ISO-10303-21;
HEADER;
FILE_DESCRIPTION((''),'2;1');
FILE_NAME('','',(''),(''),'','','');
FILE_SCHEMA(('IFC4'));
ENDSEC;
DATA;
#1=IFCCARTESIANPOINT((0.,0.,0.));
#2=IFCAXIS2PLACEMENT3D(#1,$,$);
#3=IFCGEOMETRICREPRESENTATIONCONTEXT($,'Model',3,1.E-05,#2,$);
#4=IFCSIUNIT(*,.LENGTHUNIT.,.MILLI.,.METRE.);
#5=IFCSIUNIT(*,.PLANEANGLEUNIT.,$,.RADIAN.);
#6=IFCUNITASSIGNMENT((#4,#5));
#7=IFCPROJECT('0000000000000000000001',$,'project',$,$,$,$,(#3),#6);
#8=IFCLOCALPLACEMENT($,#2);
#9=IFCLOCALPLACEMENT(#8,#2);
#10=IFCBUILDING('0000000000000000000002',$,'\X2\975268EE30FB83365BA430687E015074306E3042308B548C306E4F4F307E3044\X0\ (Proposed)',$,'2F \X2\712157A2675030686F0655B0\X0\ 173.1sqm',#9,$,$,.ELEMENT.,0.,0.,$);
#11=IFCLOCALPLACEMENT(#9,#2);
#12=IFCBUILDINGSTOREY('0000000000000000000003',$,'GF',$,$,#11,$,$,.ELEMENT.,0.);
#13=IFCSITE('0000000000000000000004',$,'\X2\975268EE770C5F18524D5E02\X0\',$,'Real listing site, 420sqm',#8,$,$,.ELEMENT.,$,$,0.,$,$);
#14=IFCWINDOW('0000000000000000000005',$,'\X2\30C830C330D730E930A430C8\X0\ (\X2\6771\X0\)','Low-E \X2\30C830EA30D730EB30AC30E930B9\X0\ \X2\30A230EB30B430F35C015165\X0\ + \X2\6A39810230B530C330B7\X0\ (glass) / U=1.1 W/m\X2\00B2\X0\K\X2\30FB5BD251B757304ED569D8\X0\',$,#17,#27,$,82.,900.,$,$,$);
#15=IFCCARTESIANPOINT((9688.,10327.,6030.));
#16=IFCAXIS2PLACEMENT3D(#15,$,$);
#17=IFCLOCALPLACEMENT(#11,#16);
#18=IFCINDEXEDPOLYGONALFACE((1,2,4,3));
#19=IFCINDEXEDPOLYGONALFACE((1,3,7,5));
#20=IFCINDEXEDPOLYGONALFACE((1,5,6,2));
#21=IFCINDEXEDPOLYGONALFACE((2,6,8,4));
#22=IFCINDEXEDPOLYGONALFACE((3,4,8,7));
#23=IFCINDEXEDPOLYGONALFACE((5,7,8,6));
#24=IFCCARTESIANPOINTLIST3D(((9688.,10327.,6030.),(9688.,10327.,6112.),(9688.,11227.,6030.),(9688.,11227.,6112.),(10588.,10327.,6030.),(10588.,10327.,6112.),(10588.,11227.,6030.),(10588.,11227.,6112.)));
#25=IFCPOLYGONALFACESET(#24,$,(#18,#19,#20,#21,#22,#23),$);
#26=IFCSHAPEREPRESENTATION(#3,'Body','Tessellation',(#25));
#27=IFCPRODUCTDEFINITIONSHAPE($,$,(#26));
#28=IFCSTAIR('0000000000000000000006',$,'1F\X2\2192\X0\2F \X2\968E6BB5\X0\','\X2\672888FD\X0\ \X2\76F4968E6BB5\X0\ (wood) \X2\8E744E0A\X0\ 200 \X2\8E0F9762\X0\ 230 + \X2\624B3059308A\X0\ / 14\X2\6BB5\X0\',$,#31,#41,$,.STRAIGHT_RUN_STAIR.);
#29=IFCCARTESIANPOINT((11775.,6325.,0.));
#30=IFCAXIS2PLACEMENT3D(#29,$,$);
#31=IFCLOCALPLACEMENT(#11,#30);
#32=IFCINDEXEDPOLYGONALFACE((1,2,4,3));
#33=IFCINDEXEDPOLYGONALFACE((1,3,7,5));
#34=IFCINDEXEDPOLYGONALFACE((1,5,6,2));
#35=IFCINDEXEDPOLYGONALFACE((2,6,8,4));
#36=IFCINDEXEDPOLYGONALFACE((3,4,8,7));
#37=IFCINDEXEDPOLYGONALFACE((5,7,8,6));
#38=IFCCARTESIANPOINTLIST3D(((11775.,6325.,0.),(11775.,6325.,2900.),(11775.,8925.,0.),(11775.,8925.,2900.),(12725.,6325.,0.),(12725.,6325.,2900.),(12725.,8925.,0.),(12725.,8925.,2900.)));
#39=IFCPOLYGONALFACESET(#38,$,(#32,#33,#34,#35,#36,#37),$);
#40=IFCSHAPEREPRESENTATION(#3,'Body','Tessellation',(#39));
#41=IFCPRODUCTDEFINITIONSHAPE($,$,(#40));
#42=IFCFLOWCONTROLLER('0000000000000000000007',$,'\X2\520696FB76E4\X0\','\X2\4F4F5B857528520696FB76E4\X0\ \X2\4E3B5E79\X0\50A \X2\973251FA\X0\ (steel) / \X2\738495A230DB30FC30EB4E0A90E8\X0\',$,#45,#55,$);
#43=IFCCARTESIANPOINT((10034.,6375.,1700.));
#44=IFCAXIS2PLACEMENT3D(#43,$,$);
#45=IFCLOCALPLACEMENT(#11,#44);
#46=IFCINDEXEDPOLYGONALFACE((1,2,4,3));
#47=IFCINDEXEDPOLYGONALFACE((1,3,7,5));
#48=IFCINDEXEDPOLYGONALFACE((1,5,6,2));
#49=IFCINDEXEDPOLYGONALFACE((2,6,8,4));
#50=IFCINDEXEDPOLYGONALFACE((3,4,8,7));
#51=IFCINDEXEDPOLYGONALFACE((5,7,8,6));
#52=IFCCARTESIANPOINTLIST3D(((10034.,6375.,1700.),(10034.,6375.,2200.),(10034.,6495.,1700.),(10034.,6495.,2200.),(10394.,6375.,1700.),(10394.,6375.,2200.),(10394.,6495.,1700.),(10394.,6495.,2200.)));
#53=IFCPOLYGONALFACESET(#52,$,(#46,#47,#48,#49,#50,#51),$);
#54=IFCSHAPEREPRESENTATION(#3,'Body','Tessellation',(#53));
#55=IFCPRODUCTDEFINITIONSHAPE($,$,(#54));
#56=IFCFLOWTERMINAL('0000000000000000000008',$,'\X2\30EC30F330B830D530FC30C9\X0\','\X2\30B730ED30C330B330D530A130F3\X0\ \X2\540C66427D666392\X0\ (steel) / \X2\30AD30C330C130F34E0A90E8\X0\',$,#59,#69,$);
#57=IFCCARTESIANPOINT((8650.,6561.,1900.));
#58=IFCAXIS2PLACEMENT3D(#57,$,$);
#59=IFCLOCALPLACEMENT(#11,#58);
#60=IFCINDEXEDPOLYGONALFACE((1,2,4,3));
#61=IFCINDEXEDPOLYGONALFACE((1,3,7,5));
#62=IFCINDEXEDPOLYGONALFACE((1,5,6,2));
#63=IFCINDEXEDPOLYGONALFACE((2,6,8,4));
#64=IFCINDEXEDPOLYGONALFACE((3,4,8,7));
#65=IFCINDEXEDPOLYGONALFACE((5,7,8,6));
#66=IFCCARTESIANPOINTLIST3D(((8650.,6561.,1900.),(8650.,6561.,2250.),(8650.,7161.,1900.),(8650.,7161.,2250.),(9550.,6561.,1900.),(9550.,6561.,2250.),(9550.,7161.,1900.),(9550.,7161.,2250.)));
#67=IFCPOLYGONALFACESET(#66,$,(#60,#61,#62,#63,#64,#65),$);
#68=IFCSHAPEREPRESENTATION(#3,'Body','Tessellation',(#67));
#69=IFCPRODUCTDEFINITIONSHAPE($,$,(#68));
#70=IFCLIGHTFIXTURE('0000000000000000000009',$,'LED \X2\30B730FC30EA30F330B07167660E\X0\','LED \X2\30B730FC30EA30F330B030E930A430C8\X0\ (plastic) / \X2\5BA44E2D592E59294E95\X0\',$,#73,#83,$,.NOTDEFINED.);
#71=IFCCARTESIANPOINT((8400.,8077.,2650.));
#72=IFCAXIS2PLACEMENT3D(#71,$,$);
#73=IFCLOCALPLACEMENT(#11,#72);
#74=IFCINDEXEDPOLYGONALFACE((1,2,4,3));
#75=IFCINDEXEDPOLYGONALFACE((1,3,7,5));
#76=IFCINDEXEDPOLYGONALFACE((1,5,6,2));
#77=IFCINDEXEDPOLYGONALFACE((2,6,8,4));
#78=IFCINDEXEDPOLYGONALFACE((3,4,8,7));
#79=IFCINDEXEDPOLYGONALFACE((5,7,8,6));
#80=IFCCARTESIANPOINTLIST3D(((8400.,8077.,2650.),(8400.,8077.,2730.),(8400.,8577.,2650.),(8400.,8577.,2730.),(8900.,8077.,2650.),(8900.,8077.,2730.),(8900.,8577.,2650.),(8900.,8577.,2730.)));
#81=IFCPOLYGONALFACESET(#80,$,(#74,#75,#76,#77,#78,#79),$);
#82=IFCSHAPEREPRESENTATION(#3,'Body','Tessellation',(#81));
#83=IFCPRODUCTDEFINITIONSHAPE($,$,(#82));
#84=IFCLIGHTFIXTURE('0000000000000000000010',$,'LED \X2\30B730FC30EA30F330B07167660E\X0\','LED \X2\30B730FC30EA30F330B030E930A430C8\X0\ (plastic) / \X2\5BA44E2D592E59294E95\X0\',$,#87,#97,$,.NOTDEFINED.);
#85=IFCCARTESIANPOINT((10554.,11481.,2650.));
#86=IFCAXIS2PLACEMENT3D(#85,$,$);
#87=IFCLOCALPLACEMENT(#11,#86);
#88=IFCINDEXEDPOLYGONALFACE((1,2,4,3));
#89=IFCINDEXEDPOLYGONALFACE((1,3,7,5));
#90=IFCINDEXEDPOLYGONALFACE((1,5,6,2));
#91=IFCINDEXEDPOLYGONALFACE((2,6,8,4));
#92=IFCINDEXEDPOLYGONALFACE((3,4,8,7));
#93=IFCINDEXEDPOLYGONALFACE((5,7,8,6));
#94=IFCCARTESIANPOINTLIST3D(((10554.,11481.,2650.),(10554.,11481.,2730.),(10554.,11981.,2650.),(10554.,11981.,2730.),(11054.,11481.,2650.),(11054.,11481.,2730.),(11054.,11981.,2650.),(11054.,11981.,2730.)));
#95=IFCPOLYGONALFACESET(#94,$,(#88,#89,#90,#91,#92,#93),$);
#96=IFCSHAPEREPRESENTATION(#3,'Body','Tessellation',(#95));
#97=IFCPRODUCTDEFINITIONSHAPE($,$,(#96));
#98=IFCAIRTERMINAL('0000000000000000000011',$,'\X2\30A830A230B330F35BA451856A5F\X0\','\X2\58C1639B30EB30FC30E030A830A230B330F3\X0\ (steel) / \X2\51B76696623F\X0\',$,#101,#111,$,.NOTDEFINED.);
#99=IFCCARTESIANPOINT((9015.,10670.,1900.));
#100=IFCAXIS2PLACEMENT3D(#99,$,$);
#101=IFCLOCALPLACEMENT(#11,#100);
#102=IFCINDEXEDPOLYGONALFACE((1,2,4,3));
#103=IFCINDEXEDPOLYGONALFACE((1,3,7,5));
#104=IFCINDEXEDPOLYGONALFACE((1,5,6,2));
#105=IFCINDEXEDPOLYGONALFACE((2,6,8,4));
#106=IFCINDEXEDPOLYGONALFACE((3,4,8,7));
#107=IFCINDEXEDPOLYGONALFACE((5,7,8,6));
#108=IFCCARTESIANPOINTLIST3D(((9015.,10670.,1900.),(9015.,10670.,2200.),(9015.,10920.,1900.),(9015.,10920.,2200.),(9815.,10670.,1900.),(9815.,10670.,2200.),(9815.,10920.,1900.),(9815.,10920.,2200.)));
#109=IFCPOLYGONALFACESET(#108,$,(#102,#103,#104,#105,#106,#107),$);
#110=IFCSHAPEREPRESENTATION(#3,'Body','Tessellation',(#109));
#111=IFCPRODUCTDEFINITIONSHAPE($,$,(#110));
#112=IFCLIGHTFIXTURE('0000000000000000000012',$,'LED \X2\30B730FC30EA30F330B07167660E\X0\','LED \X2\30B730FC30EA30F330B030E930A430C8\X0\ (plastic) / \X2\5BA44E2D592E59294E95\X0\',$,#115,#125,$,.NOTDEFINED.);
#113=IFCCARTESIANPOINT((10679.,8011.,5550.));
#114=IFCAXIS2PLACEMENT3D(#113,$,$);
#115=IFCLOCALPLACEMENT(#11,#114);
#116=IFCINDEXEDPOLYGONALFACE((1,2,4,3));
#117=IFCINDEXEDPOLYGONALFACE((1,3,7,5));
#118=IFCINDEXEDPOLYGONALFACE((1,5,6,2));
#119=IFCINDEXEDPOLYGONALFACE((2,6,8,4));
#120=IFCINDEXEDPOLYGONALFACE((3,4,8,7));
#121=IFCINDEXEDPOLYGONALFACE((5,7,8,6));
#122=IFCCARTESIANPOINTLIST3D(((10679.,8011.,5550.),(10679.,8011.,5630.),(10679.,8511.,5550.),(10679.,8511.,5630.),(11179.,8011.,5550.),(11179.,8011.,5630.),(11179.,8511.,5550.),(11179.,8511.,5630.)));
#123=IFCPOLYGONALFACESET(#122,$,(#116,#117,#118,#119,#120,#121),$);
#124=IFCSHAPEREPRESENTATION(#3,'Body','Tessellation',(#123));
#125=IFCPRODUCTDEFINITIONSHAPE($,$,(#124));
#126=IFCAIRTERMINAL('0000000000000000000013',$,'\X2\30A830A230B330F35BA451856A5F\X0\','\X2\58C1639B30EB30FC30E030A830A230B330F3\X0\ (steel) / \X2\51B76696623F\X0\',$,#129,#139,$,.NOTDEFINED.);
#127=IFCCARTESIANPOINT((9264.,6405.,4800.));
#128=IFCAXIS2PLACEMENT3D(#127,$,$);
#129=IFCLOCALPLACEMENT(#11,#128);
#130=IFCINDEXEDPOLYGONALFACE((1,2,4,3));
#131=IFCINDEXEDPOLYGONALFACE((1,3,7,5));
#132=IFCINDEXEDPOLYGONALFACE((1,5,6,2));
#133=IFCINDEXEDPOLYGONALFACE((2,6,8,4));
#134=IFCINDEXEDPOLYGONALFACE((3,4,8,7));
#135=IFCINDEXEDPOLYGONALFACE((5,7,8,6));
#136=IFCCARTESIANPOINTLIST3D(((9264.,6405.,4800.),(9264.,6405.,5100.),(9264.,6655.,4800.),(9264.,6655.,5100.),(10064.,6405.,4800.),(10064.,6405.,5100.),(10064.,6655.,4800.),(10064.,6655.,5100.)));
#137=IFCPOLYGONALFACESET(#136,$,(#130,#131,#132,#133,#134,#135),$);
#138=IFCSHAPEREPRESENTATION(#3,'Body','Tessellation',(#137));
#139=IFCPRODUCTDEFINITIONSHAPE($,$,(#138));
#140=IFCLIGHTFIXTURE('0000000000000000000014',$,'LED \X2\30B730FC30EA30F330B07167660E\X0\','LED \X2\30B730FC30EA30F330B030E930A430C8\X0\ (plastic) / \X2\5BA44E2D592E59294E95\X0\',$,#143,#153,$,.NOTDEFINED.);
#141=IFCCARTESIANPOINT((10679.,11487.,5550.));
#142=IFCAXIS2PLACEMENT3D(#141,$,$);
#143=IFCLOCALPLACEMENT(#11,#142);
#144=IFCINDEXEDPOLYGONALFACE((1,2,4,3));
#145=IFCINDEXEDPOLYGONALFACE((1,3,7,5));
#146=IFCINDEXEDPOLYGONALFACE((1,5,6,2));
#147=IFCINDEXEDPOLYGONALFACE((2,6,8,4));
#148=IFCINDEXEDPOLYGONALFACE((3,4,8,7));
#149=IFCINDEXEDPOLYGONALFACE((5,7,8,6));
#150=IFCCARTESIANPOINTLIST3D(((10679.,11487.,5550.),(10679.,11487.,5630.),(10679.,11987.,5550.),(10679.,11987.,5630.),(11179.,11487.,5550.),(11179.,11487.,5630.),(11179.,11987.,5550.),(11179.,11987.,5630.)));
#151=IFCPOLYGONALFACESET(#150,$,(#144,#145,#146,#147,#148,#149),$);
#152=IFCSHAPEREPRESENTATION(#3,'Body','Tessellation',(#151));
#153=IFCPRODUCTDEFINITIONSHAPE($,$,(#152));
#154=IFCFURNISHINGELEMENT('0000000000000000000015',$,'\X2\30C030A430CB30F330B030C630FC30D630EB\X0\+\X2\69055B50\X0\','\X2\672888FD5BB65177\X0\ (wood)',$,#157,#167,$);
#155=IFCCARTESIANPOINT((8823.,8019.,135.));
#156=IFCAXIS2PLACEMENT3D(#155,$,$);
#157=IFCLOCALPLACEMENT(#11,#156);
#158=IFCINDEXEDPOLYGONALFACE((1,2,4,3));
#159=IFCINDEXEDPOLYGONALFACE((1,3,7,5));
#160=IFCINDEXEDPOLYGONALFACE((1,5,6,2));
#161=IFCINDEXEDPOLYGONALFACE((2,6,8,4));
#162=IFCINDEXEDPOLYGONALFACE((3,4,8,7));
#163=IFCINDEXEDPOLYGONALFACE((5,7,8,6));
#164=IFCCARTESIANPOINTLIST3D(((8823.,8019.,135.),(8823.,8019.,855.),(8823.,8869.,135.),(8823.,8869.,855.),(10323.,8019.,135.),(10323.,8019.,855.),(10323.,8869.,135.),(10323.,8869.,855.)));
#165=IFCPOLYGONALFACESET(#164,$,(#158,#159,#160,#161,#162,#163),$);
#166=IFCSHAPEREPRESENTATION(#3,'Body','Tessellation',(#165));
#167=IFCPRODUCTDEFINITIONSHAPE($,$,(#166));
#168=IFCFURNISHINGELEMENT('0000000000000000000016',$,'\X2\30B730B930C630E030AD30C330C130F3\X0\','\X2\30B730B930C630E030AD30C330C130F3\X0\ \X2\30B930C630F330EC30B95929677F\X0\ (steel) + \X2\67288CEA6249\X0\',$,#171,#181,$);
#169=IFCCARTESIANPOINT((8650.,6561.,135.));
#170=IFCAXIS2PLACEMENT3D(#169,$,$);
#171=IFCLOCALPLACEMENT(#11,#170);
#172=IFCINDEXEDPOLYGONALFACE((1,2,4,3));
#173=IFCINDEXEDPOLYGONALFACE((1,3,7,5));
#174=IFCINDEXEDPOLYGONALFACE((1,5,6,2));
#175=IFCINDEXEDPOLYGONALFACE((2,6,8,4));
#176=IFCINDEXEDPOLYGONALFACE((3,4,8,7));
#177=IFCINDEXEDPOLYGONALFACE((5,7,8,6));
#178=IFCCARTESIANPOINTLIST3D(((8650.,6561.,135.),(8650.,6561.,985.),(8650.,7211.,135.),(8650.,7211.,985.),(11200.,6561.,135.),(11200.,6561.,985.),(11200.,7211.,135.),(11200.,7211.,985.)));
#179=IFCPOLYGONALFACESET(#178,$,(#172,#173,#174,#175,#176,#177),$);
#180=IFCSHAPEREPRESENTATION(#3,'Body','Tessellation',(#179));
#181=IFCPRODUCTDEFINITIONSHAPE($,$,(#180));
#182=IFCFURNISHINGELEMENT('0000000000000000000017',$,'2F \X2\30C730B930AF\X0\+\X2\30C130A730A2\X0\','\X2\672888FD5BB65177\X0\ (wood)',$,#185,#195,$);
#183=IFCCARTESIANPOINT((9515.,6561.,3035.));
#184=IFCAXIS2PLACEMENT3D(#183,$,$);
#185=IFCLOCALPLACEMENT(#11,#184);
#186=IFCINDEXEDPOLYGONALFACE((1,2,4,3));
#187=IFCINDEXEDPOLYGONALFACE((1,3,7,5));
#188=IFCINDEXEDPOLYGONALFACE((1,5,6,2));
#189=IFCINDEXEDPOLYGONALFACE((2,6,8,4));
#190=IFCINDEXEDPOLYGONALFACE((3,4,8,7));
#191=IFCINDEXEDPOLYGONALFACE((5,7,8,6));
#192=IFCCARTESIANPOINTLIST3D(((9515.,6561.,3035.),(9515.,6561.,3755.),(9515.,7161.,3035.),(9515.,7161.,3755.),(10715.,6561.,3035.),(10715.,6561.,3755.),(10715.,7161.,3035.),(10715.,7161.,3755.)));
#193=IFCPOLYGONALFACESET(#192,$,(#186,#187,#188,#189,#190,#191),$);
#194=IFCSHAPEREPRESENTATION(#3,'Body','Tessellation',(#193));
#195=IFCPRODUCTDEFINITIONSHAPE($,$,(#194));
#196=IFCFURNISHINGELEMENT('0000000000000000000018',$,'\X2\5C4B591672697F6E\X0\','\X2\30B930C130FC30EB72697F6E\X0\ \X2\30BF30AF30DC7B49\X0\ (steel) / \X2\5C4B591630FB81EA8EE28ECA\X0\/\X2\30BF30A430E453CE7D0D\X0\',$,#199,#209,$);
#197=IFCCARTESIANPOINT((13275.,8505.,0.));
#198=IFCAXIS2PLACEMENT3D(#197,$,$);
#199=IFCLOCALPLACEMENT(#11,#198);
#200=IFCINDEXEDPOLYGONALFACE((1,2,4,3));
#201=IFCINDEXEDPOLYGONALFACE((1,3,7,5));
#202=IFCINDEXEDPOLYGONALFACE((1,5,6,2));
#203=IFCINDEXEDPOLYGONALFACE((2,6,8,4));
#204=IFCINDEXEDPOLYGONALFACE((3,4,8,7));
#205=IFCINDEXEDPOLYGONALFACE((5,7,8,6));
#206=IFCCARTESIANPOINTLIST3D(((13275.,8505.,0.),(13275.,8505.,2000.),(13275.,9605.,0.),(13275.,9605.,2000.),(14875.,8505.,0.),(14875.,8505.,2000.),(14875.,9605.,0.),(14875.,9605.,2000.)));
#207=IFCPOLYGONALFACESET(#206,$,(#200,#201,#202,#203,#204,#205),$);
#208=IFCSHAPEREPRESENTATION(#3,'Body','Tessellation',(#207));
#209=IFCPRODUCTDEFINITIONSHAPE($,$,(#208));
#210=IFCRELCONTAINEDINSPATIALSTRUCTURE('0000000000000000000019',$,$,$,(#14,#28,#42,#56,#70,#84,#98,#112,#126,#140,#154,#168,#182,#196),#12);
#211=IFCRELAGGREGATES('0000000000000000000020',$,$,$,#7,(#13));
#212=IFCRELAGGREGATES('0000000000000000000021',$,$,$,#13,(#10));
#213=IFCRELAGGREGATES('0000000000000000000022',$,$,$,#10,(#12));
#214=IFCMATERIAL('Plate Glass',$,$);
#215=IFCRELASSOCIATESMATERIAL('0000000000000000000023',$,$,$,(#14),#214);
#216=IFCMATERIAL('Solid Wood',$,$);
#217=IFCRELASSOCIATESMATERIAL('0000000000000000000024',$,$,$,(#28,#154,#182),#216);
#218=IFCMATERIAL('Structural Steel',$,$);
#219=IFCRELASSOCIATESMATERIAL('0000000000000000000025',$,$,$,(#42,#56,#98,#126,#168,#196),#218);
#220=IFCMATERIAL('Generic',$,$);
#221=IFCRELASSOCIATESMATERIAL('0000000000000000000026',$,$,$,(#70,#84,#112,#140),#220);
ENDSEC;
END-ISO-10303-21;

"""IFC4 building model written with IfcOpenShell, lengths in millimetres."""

from ifc_helpers import new_model, si_unit, frame, frame_2d, origin, place, context, project, spatial, rectangle, extrude, material, element, save


model = new_model("IFC4")

# Units and contexts
model_context = context("Model", 3, precision=1e-05, world=origin())
ifc_project = project(units=[si_unit("LENGTHUNIT", "METRE", prefix="MILLI"), si_unit("PLANEANGLEUNIT", "RADIAN")], contexts=[model_context])

# Site, building, storey
site_placement = place(None, origin())
site = spatial("IfcSite", under=ifc_project, at=site_placement, Name="青森県弘前市", ObjectType="Real listing site, 420sqm", CompositionType="ELEMENT", RefElevation=0.0)
building_placement = place(site_placement, origin())
building = spatial("IfcBuilding", under=site, at=building_placement, Name="青森・茶室と縁側のある和の住まい (Proposed)", ObjectType="2F 無垢材と漆喰 173.1sqm", CompositionType="ELEMENT", ElevationOfRefHeight=0.0, ElevationOfTerrain=0.0)
storey_placement = place(building_placement, origin())
storey = spatial("IfcBuildingStorey", under=building, at=storey_placement, Name="GF", CompositionType="ELEMENT", Elevation=0.0)

# Shared definitions
ifc_material_1 = material(Name="Solid Wood")

# Window
ifc_material_2 = material(Name="Plate Glass")
window_placement = place(storey_placement, frame((9688.0, 10327.0, 6030.0)))
element("IfcWindow", 1, at=window_placement, inside=storey, material=ifc_material_2, Name="トップライト (東)", Description="Low-E トリプルガラス アルゴン封入 + 樹脂サッシ (glass) / U=1.1 W/m²K・寒冷地仕様", OverallHeight=82.0, OverallWidth=900.0, context=model_context, shape_type="SweptSolid", body=[
    extrude(rectangle(XDim=900.0, YDim=900.0, at=frame_2d((450.0, 450.0))), frame((9688.0, 10327.0, 6030.0)), (0.0, 0.0, 1.0), 82.0),
])

# Stair
stair_placement = place(storey_placement, frame((11775.0, 6325.0, 0.0)))
element("IfcStair", 2, at=stair_placement, inside=storey, material=ifc_material_1, Name="1F→2F 階段", Description="木製 直階段 (wood) 蹴上 200 踏面 230 + 手すり / 14段", PredefinedType="STRAIGHT_RUN_STAIR", context=model_context, shape_type="SweptSolid", body=[
    extrude(rectangle(XDim=950.0, YDim=2600.0, at=frame_2d((475.0, 1300.0))), frame((11775.0, 6325.0, 0.0)), (0.0, 0.0, 1.0), 2900.0),
])

# Flow controller
ifc_material_3 = material(Name="Structural Steel")
flow_controller_placement = place(storey_placement, frame((10034.0, 6375.0, 1700.0)))
element("IfcFlowController", 3, at=flow_controller_placement, inside=storey, material=ifc_material_3, Name="分電盤", Description="住宅用分電盤 主幹50A 露出 (steel) / 玄関ホール上部", context=model_context, shape_type="SweptSolid", body=[
    extrude(rectangle(XDim=360.0, YDim=120.0, at=frame_2d((180.0, 60.0))), frame((10034.0, 6375.0, 1700.0)), (0.0, 0.0, 1.0), 500.0),
])

# Flow terminal
flow_terminal_placement = place(storey_placement, frame((8650.0, 6561.0, 1900.0)))
element("IfcFlowTerminal", 4, at=flow_terminal_placement, inside=storey, material=ifc_material_3, Name="レンジフード", Description="シロッコファン 同時給排 (steel) / キッチン上部", context=model_context, shape_type="SweptSolid", body=[
    extrude(rectangle(XDim=900.0, YDim=600.0, at=frame_2d((450.0, 300.0))), frame((8650.0, 6561.0, 1900.0)), (0.0, 0.0, 1.0), 350.0),
])

# Light fixtures
ifc_material_4 = material(Name="Generic")
light_fixture_1_placement = place(storey_placement, frame((8400.0, 8077.0, 2650.0)))
element("IfcLightFixture", 5, at=light_fixture_1_placement, inside=storey, material=ifc_material_4, Name="LED シーリング照明", Description="LED シーリングライト (plastic) / 室中央天井", PredefinedType="NOTDEFINED", context=model_context, shape_type="SweptSolid", body=[
    extrude(rectangle(XDim=500.0, YDim=500.0, at=frame_2d((250.0, 250.0))), frame((8400.0, 8077.0, 2650.0)), (0.0, 0.0, 1.0), 80.0),
])
light_fixture_2_placement = place(storey_placement, frame((10554.0, 11481.0, 2650.0)))
element("IfcLightFixture", 6, at=light_fixture_2_placement, inside=storey, material=ifc_material_4, Name="LED シーリング照明", Description="LED シーリングライト (plastic) / 室中央天井", PredefinedType="NOTDEFINED", context=model_context, shape_type="SweptSolid", body=[
    extrude(rectangle(XDim=500.0, YDim=500.0, at=frame_2d((250.0, 250.0))), frame((10554.0, 11481.0, 2650.0)), (0.0, 0.0, 1.0), 80.0),
])

# Air terminal
air_terminal_1_placement = place(storey_placement, frame((9015.0, 10670.0, 1900.0)))
element("IfcAirTerminal", 7, at=air_terminal_1_placement, inside=storey, material=ifc_material_3, Name="エアコン室内機", Description="壁掛ルームエアコン (steel) / 冷暖房", PredefinedType="NOTDEFINED", context=model_context, shape_type="SweptSolid", body=[
    extrude(rectangle(XDim=800.0, YDim=250.0, at=frame_2d((400.0, 125.0))), frame((9015.0, 10670.0, 1900.0)), (0.0, 0.0, 1.0), 300.0),
])

# Light fixture
light_fixture_3_placement = place(storey_placement, frame((10679.0, 8011.0, 5550.0)))
element("IfcLightFixture", 8, at=light_fixture_3_placement, inside=storey, material=ifc_material_4, Name="LED シーリング照明", Description="LED シーリングライト (plastic) / 室中央天井", PredefinedType="NOTDEFINED", context=model_context, shape_type="SweptSolid", body=[
    extrude(rectangle(XDim=500.0, YDim=500.0, at=frame_2d((250.0, 250.0))), frame((10679.0, 8011.0, 5550.0)), (0.0, 0.0, 1.0), 80.0),
])

# Air terminal
air_terminal_2_placement = place(storey_placement, frame((9264.0, 6405.0, 4800.0)))
element("IfcAirTerminal", 9, at=air_terminal_2_placement, inside=storey, material=ifc_material_3, Name="エアコン室内機", Description="壁掛ルームエアコン (steel) / 冷暖房", PredefinedType="NOTDEFINED", context=model_context, shape_type="SweptSolid", body=[
    extrude(rectangle(XDim=800.0, YDim=250.0, at=frame_2d((400.0, 125.0))), frame((9264.0, 6405.0, 4800.0)), (0.0, 0.0, 1.0), 300.0),
])

# Light fixture
light_fixture_4_placement = place(storey_placement, frame((10679.0, 11487.0, 5550.0)))
element("IfcLightFixture", 10, at=light_fixture_4_placement, inside=storey, material=ifc_material_4, Name="LED シーリング照明", Description="LED シーリングライト (plastic) / 室中央天井", PredefinedType="NOTDEFINED", context=model_context, shape_type="SweptSolid", body=[
    extrude(rectangle(XDim=500.0, YDim=500.0, at=frame_2d((250.0, 250.0))), frame((10679.0, 11487.0, 5550.0)), (0.0, 0.0, 1.0), 80.0),
])

# Furnishing elements
furnishing_1_placement = place(storey_placement, frame((8823.0, 8019.0, 135.0)))
element("IfcFurnishingElement", 11, at=furnishing_1_placement, inside=storey, material=ifc_material_1, Name="ダイニングテーブル+椅子", Description="木製家具 (wood)", context=model_context, shape_type="SweptSolid", body=[
    extrude(rectangle(XDim=1500.0, YDim=850.0, at=frame_2d((750.0, 425.0))), frame((8823.0, 8019.0, 135.0)), (0.0, 0.0, 1.0), 720.0),
])
furnishing_2_placement = place(storey_placement, frame((8650.0, 6561.0, 135.0)))
element("IfcFurnishingElement", 12, at=furnishing_2_placement, inside=storey, material=ifc_material_3, Name="システムキッチン", Description="システムキッチン ステンレス天板 (steel) + 木質扉", context=model_context, shape_type="SweptSolid", body=[
    extrude(rectangle(XDim=2550.0, YDim=650.0, at=frame_2d((1275.0, 325.0))), frame((8650.0, 6561.0, 135.0)), (0.0, 0.0, 1.0), 850.0),
])
furnishing_3_placement = place(storey_placement, frame((9515.0, 6561.0, 3035.0)))
element("IfcFurnishingElement", 13, at=furnishing_3_placement, inside=storey, material=ifc_material_1, Name="2F デスク+チェア", Description="木製家具 (wood)", context=model_context, shape_type="SweptSolid", body=[
    extrude(rectangle(XDim=1200.0, YDim=600.0, at=frame_2d((600.0, 300.0))), frame((9515.0, 6561.0, 3035.0)), (0.0, 0.0, 1.0), 720.0),
])
furnishing_4_placement = place(storey_placement, frame((13275.0, 8505.0, 0.0)))
element("IfcFurnishingElement", 14, at=furnishing_4_placement, inside=storey, material=ifc_material_3, Name="屋外物置", Description="スチール物置 タクボ等 (steel) / 屋外・自転車/タイヤ収納", context=model_context, shape_type="SweptSolid", body=[
    extrude(rectangle(XDim=1600.0, YDim=1100.0, at=frame_2d((800.0, 550.0))), frame((13275.0, 8505.0, 0.0)), (0.0, 0.0, 1.0), 2000.0),
])

save(model, "model.ifc")
